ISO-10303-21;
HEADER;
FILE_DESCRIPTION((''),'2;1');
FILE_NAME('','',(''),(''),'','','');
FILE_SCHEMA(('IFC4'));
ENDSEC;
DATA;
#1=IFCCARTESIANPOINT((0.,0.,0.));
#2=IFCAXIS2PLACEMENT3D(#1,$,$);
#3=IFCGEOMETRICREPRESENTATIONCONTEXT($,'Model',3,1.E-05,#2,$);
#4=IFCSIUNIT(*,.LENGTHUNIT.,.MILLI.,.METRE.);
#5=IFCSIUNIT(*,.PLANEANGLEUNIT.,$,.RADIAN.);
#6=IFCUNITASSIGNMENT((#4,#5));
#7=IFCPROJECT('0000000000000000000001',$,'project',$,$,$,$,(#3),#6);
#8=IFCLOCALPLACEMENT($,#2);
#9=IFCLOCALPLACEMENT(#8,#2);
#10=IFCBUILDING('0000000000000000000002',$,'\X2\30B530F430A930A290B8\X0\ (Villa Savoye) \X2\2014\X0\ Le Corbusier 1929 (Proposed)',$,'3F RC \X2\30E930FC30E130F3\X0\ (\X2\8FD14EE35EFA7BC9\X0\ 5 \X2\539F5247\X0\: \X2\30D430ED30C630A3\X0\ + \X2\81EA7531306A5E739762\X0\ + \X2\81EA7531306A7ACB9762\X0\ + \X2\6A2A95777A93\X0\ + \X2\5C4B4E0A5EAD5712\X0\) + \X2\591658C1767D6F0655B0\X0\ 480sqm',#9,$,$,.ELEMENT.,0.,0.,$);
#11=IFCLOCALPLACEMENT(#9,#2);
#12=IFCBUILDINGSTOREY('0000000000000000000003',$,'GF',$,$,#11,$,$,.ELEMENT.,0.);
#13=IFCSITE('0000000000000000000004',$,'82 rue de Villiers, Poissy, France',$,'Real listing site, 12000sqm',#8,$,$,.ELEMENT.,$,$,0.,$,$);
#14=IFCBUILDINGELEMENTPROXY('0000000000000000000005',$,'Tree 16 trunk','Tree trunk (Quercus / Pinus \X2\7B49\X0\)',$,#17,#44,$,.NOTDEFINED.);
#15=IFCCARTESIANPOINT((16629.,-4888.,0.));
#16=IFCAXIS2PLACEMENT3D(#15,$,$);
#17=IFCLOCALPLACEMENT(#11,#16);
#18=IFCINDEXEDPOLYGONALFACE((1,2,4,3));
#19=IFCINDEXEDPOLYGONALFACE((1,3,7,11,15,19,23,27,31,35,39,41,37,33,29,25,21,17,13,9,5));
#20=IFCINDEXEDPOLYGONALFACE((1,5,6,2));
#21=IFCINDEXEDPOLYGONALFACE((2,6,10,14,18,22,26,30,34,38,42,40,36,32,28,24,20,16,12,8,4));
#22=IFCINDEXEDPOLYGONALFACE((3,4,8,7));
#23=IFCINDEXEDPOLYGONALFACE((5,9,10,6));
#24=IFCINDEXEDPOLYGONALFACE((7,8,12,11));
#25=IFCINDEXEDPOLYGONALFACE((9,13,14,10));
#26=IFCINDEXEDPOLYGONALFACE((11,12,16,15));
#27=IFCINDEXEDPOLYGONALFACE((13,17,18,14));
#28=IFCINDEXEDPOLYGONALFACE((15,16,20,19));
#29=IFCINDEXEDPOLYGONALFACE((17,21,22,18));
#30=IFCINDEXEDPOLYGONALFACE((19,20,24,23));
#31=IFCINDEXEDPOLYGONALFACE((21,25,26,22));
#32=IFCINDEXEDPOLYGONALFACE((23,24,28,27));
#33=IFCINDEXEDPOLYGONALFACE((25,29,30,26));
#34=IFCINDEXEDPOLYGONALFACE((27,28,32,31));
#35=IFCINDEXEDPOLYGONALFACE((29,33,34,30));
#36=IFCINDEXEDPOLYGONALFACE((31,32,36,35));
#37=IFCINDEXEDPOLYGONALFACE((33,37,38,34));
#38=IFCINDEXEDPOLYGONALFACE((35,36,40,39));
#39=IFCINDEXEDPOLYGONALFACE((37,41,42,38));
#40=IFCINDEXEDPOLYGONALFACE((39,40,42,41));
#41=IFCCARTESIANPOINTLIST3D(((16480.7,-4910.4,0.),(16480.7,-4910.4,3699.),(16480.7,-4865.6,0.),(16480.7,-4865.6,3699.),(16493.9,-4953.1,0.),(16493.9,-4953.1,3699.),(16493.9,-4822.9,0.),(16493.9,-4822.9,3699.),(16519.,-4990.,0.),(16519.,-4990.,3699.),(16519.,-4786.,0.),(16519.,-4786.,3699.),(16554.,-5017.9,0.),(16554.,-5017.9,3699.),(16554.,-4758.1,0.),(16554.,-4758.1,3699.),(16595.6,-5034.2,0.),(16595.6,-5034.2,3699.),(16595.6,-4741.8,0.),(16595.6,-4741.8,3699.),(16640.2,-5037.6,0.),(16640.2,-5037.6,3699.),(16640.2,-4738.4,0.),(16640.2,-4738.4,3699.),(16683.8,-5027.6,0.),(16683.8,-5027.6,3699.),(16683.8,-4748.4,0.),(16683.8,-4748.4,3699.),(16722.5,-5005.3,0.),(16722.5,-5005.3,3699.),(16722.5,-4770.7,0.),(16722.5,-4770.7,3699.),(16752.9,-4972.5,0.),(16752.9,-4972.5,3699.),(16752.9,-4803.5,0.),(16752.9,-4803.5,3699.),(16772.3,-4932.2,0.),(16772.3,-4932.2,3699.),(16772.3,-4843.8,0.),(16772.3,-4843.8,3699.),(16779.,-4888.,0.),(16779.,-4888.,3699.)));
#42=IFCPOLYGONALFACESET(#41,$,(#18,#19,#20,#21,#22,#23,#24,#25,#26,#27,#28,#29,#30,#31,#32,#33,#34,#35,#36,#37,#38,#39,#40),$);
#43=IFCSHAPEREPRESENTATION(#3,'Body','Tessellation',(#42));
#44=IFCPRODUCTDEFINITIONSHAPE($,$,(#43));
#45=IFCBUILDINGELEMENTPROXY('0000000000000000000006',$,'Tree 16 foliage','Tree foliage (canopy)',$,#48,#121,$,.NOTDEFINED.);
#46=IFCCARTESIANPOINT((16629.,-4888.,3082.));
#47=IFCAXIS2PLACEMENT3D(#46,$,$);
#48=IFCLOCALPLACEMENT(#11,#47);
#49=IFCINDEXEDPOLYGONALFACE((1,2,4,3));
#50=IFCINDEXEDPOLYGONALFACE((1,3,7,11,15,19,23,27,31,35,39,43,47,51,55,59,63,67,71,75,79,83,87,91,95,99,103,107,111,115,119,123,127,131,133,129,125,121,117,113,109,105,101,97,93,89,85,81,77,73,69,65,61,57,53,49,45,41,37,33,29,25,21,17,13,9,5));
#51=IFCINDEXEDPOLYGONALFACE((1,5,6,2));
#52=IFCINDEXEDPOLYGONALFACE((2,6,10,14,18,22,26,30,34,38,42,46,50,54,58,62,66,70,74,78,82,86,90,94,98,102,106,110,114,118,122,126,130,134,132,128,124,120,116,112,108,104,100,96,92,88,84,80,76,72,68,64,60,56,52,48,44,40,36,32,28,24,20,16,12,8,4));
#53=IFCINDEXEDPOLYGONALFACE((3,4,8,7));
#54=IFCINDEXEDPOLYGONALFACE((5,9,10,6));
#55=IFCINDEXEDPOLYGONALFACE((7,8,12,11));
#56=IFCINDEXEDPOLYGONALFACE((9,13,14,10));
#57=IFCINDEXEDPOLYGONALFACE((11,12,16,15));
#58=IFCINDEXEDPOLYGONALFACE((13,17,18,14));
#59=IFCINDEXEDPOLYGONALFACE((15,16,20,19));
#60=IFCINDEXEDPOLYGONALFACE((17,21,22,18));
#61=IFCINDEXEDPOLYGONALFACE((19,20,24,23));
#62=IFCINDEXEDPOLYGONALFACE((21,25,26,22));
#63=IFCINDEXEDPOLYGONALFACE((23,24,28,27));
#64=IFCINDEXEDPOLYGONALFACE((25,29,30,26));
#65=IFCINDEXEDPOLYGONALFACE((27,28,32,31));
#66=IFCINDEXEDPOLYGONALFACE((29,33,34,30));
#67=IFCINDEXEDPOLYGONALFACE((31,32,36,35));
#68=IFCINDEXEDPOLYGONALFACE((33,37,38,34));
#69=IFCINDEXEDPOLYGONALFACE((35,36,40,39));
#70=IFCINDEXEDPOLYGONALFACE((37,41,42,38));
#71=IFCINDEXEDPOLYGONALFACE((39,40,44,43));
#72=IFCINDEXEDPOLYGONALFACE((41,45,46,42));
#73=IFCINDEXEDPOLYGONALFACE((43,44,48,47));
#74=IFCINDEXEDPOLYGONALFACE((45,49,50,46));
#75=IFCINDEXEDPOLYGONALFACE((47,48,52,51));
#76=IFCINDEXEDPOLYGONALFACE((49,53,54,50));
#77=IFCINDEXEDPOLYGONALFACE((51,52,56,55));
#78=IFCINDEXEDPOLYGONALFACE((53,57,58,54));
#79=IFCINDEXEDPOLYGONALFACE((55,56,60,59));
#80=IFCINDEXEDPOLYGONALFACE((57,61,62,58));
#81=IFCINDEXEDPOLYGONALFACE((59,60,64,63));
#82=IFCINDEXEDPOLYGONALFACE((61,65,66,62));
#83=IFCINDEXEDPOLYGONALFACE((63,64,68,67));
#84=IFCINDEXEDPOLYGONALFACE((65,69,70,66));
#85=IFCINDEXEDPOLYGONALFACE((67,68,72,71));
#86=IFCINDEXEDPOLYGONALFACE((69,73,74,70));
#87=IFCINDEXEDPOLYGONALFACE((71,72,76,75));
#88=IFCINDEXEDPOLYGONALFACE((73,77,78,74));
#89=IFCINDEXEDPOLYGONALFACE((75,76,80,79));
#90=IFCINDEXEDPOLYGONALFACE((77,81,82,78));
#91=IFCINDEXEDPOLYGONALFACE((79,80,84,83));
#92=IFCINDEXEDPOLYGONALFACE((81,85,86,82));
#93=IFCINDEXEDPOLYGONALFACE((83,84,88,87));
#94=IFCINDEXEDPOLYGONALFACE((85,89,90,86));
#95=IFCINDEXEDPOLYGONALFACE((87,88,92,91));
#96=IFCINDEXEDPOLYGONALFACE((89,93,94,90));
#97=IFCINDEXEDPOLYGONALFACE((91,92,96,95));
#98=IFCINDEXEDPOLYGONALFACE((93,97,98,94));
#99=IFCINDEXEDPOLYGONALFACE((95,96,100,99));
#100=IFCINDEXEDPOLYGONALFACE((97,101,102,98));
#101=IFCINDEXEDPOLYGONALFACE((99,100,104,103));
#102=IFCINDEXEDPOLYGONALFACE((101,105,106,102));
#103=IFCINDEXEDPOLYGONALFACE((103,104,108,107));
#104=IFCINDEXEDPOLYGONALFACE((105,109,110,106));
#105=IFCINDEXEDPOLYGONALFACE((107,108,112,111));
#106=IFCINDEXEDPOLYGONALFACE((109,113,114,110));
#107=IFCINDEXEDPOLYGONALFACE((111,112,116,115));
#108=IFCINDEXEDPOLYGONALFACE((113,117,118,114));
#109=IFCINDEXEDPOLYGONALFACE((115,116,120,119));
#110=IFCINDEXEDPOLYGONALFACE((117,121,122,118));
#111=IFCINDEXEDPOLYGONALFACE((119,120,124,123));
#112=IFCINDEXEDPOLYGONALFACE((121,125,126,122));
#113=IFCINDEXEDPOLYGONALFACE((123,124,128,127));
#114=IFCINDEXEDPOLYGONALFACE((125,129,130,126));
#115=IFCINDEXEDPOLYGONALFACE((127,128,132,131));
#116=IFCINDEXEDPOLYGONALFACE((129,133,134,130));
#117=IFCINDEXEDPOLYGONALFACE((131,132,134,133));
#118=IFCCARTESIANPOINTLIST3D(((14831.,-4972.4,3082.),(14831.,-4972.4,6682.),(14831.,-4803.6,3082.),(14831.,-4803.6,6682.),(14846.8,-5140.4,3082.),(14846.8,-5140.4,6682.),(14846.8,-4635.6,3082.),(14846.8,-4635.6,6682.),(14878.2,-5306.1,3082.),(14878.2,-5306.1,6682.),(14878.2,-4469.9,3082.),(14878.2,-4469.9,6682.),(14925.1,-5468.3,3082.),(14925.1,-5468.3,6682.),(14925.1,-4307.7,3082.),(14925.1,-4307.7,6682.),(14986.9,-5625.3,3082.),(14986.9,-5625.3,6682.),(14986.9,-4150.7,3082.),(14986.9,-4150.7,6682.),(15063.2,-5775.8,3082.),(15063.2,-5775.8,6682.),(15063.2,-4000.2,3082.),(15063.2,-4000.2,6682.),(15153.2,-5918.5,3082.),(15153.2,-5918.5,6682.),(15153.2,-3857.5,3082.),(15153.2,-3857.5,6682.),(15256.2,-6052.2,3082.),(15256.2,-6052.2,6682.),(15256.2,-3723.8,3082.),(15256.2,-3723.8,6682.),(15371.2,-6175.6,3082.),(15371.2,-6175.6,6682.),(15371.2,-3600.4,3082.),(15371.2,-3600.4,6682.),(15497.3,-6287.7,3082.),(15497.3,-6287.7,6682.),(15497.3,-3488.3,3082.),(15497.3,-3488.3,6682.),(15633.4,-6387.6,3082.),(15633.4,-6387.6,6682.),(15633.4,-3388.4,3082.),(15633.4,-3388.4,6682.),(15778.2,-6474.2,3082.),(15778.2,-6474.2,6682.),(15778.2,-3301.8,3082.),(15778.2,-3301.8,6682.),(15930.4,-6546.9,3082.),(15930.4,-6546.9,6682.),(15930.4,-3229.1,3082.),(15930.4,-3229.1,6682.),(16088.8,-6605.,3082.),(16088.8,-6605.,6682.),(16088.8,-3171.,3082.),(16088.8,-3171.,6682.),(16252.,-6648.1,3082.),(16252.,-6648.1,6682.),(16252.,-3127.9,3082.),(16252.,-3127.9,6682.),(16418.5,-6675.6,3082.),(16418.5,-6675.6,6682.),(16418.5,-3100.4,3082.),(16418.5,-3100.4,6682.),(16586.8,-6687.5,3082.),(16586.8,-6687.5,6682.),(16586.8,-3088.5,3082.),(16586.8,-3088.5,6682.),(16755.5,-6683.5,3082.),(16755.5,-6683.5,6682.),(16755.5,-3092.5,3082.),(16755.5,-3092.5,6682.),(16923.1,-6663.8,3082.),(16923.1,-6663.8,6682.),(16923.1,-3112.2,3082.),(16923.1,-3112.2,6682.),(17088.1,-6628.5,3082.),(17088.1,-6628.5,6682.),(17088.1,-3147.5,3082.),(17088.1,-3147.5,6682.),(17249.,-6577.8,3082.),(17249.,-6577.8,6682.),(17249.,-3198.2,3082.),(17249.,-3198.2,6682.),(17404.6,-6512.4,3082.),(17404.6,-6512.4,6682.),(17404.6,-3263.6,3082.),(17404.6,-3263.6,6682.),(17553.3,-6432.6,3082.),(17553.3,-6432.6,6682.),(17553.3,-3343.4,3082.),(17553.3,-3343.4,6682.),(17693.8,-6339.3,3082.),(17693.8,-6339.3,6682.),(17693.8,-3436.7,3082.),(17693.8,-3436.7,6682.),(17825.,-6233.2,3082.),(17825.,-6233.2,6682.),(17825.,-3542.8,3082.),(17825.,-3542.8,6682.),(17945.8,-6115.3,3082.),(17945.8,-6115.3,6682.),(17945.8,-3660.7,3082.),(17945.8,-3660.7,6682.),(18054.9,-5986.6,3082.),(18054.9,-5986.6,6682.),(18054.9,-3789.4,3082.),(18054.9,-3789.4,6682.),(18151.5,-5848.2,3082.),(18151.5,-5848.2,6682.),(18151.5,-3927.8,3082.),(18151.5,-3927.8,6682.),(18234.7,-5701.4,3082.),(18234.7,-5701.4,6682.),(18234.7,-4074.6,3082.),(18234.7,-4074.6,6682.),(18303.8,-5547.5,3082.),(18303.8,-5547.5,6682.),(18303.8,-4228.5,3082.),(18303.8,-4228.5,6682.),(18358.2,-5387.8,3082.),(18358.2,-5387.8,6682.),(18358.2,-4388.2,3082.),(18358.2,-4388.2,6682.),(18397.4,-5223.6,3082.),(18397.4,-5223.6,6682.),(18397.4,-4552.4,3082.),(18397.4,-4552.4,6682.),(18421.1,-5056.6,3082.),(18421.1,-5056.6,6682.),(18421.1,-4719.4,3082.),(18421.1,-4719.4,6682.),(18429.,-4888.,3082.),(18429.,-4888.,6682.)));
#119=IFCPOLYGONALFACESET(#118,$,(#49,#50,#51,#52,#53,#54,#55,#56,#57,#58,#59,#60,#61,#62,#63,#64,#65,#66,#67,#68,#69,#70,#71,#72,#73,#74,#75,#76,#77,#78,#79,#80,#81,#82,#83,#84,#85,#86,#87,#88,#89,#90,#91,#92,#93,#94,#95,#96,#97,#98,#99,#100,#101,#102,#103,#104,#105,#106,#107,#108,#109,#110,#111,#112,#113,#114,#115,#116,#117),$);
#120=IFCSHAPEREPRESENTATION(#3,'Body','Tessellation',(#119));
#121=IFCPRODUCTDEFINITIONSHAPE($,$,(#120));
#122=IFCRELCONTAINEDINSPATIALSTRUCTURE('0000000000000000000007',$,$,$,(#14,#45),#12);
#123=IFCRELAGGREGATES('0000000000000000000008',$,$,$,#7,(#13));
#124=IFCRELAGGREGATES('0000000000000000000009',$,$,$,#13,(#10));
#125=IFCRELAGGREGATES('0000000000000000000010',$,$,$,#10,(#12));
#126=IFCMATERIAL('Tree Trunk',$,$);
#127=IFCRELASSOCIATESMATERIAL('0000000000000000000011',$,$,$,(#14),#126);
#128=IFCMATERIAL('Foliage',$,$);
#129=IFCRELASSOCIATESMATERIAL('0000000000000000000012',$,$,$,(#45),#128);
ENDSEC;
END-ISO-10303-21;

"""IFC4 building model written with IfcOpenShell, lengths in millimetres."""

from ifc_helpers import new_model, si_unit, frame, origin, origin_2d, place, context, project, spatial, circle, extrude, material, element, save


model = new_model("IFC4")

# Units and contexts
model_context = context("Model", 3, precision=1e-05, world=origin())
ifc_project = project(units=[si_unit("LENGTHUNIT", "METRE", prefix="MILLI"), si_unit("PLANEANGLEUNIT", "RADIAN")], contexts=[model_context])

# Site, building, storey
site_placement = place(None, origin())
site = spatial("IfcSite", under=ifc_project, at=site_placement, Name="82 rue de Villiers, Poissy, France", ObjectType="Real listing site, 12000sqm", CompositionType="ELEMENT", RefElevation=0.0)
building_placement = place(site_placement, origin())
building = spatial("IfcBuilding", under=site, at=building_placement, Name="サヴォア邸 (Villa Savoye) — Le Corbusier 1929 (Proposed)", ObjectType="3F RC ラーメン (近代建築 5 原則: ピロティ + 自由な平面 + 自由な立面 + 横長窓 + 屋上庭園) + 外壁白漆喰 480sqm", CompositionType="ELEMENT", ElevationOfRefHeight=0.0, ElevationOfTerrain=0.0)
storey_placement = place(building_placement, origin())
storey = spatial("IfcBuildingStorey", under=building, at=storey_placement, Name="GF", CompositionType="ELEMENT", Elevation=0.0)

# Building element proxies
ifc_material_1 = material(Name="Tree Trunk")
ifc_material_2 = material(Name="Foliage")
proxy_1_placement = place(storey_placement, frame((16629.0, -4888.0, 0.0)))
element("IfcBuildingElementProxy", 1, at=proxy_1_placement, inside=storey, material=ifc_material_1, Name="Tree 16 trunk", Description="Tree trunk (Quercus / Pinus 等)", PredefinedType="NOTDEFINED", context=model_context, shape_type="SweptSolid", body=[
    extrude(circle(Radius=150.0, at=origin_2d()), frame((16629.0, -4888.0, 0.0)), (0.0, 0.0, 1.0), 3699.0),
])
proxy_2_placement = place(storey_placement, frame((16629.0, -4888.0, 3082.0)))
element("IfcBuildingElementProxy", 2, at=proxy_2_placement, inside=storey, material=ifc_material_2, Name="Tree 16 foliage", Description="Tree foliage (canopy)", PredefinedType="NOTDEFINED", context=model_context, shape_type="SweptSolid", body=[
    extrude(circle(Radius=1800.0, at=origin_2d()), frame((16629.0, -4888.0, 3082.0)), (0.0, 0.0, 1.0), 3600.0),
])

save(model, "model.ifc")
